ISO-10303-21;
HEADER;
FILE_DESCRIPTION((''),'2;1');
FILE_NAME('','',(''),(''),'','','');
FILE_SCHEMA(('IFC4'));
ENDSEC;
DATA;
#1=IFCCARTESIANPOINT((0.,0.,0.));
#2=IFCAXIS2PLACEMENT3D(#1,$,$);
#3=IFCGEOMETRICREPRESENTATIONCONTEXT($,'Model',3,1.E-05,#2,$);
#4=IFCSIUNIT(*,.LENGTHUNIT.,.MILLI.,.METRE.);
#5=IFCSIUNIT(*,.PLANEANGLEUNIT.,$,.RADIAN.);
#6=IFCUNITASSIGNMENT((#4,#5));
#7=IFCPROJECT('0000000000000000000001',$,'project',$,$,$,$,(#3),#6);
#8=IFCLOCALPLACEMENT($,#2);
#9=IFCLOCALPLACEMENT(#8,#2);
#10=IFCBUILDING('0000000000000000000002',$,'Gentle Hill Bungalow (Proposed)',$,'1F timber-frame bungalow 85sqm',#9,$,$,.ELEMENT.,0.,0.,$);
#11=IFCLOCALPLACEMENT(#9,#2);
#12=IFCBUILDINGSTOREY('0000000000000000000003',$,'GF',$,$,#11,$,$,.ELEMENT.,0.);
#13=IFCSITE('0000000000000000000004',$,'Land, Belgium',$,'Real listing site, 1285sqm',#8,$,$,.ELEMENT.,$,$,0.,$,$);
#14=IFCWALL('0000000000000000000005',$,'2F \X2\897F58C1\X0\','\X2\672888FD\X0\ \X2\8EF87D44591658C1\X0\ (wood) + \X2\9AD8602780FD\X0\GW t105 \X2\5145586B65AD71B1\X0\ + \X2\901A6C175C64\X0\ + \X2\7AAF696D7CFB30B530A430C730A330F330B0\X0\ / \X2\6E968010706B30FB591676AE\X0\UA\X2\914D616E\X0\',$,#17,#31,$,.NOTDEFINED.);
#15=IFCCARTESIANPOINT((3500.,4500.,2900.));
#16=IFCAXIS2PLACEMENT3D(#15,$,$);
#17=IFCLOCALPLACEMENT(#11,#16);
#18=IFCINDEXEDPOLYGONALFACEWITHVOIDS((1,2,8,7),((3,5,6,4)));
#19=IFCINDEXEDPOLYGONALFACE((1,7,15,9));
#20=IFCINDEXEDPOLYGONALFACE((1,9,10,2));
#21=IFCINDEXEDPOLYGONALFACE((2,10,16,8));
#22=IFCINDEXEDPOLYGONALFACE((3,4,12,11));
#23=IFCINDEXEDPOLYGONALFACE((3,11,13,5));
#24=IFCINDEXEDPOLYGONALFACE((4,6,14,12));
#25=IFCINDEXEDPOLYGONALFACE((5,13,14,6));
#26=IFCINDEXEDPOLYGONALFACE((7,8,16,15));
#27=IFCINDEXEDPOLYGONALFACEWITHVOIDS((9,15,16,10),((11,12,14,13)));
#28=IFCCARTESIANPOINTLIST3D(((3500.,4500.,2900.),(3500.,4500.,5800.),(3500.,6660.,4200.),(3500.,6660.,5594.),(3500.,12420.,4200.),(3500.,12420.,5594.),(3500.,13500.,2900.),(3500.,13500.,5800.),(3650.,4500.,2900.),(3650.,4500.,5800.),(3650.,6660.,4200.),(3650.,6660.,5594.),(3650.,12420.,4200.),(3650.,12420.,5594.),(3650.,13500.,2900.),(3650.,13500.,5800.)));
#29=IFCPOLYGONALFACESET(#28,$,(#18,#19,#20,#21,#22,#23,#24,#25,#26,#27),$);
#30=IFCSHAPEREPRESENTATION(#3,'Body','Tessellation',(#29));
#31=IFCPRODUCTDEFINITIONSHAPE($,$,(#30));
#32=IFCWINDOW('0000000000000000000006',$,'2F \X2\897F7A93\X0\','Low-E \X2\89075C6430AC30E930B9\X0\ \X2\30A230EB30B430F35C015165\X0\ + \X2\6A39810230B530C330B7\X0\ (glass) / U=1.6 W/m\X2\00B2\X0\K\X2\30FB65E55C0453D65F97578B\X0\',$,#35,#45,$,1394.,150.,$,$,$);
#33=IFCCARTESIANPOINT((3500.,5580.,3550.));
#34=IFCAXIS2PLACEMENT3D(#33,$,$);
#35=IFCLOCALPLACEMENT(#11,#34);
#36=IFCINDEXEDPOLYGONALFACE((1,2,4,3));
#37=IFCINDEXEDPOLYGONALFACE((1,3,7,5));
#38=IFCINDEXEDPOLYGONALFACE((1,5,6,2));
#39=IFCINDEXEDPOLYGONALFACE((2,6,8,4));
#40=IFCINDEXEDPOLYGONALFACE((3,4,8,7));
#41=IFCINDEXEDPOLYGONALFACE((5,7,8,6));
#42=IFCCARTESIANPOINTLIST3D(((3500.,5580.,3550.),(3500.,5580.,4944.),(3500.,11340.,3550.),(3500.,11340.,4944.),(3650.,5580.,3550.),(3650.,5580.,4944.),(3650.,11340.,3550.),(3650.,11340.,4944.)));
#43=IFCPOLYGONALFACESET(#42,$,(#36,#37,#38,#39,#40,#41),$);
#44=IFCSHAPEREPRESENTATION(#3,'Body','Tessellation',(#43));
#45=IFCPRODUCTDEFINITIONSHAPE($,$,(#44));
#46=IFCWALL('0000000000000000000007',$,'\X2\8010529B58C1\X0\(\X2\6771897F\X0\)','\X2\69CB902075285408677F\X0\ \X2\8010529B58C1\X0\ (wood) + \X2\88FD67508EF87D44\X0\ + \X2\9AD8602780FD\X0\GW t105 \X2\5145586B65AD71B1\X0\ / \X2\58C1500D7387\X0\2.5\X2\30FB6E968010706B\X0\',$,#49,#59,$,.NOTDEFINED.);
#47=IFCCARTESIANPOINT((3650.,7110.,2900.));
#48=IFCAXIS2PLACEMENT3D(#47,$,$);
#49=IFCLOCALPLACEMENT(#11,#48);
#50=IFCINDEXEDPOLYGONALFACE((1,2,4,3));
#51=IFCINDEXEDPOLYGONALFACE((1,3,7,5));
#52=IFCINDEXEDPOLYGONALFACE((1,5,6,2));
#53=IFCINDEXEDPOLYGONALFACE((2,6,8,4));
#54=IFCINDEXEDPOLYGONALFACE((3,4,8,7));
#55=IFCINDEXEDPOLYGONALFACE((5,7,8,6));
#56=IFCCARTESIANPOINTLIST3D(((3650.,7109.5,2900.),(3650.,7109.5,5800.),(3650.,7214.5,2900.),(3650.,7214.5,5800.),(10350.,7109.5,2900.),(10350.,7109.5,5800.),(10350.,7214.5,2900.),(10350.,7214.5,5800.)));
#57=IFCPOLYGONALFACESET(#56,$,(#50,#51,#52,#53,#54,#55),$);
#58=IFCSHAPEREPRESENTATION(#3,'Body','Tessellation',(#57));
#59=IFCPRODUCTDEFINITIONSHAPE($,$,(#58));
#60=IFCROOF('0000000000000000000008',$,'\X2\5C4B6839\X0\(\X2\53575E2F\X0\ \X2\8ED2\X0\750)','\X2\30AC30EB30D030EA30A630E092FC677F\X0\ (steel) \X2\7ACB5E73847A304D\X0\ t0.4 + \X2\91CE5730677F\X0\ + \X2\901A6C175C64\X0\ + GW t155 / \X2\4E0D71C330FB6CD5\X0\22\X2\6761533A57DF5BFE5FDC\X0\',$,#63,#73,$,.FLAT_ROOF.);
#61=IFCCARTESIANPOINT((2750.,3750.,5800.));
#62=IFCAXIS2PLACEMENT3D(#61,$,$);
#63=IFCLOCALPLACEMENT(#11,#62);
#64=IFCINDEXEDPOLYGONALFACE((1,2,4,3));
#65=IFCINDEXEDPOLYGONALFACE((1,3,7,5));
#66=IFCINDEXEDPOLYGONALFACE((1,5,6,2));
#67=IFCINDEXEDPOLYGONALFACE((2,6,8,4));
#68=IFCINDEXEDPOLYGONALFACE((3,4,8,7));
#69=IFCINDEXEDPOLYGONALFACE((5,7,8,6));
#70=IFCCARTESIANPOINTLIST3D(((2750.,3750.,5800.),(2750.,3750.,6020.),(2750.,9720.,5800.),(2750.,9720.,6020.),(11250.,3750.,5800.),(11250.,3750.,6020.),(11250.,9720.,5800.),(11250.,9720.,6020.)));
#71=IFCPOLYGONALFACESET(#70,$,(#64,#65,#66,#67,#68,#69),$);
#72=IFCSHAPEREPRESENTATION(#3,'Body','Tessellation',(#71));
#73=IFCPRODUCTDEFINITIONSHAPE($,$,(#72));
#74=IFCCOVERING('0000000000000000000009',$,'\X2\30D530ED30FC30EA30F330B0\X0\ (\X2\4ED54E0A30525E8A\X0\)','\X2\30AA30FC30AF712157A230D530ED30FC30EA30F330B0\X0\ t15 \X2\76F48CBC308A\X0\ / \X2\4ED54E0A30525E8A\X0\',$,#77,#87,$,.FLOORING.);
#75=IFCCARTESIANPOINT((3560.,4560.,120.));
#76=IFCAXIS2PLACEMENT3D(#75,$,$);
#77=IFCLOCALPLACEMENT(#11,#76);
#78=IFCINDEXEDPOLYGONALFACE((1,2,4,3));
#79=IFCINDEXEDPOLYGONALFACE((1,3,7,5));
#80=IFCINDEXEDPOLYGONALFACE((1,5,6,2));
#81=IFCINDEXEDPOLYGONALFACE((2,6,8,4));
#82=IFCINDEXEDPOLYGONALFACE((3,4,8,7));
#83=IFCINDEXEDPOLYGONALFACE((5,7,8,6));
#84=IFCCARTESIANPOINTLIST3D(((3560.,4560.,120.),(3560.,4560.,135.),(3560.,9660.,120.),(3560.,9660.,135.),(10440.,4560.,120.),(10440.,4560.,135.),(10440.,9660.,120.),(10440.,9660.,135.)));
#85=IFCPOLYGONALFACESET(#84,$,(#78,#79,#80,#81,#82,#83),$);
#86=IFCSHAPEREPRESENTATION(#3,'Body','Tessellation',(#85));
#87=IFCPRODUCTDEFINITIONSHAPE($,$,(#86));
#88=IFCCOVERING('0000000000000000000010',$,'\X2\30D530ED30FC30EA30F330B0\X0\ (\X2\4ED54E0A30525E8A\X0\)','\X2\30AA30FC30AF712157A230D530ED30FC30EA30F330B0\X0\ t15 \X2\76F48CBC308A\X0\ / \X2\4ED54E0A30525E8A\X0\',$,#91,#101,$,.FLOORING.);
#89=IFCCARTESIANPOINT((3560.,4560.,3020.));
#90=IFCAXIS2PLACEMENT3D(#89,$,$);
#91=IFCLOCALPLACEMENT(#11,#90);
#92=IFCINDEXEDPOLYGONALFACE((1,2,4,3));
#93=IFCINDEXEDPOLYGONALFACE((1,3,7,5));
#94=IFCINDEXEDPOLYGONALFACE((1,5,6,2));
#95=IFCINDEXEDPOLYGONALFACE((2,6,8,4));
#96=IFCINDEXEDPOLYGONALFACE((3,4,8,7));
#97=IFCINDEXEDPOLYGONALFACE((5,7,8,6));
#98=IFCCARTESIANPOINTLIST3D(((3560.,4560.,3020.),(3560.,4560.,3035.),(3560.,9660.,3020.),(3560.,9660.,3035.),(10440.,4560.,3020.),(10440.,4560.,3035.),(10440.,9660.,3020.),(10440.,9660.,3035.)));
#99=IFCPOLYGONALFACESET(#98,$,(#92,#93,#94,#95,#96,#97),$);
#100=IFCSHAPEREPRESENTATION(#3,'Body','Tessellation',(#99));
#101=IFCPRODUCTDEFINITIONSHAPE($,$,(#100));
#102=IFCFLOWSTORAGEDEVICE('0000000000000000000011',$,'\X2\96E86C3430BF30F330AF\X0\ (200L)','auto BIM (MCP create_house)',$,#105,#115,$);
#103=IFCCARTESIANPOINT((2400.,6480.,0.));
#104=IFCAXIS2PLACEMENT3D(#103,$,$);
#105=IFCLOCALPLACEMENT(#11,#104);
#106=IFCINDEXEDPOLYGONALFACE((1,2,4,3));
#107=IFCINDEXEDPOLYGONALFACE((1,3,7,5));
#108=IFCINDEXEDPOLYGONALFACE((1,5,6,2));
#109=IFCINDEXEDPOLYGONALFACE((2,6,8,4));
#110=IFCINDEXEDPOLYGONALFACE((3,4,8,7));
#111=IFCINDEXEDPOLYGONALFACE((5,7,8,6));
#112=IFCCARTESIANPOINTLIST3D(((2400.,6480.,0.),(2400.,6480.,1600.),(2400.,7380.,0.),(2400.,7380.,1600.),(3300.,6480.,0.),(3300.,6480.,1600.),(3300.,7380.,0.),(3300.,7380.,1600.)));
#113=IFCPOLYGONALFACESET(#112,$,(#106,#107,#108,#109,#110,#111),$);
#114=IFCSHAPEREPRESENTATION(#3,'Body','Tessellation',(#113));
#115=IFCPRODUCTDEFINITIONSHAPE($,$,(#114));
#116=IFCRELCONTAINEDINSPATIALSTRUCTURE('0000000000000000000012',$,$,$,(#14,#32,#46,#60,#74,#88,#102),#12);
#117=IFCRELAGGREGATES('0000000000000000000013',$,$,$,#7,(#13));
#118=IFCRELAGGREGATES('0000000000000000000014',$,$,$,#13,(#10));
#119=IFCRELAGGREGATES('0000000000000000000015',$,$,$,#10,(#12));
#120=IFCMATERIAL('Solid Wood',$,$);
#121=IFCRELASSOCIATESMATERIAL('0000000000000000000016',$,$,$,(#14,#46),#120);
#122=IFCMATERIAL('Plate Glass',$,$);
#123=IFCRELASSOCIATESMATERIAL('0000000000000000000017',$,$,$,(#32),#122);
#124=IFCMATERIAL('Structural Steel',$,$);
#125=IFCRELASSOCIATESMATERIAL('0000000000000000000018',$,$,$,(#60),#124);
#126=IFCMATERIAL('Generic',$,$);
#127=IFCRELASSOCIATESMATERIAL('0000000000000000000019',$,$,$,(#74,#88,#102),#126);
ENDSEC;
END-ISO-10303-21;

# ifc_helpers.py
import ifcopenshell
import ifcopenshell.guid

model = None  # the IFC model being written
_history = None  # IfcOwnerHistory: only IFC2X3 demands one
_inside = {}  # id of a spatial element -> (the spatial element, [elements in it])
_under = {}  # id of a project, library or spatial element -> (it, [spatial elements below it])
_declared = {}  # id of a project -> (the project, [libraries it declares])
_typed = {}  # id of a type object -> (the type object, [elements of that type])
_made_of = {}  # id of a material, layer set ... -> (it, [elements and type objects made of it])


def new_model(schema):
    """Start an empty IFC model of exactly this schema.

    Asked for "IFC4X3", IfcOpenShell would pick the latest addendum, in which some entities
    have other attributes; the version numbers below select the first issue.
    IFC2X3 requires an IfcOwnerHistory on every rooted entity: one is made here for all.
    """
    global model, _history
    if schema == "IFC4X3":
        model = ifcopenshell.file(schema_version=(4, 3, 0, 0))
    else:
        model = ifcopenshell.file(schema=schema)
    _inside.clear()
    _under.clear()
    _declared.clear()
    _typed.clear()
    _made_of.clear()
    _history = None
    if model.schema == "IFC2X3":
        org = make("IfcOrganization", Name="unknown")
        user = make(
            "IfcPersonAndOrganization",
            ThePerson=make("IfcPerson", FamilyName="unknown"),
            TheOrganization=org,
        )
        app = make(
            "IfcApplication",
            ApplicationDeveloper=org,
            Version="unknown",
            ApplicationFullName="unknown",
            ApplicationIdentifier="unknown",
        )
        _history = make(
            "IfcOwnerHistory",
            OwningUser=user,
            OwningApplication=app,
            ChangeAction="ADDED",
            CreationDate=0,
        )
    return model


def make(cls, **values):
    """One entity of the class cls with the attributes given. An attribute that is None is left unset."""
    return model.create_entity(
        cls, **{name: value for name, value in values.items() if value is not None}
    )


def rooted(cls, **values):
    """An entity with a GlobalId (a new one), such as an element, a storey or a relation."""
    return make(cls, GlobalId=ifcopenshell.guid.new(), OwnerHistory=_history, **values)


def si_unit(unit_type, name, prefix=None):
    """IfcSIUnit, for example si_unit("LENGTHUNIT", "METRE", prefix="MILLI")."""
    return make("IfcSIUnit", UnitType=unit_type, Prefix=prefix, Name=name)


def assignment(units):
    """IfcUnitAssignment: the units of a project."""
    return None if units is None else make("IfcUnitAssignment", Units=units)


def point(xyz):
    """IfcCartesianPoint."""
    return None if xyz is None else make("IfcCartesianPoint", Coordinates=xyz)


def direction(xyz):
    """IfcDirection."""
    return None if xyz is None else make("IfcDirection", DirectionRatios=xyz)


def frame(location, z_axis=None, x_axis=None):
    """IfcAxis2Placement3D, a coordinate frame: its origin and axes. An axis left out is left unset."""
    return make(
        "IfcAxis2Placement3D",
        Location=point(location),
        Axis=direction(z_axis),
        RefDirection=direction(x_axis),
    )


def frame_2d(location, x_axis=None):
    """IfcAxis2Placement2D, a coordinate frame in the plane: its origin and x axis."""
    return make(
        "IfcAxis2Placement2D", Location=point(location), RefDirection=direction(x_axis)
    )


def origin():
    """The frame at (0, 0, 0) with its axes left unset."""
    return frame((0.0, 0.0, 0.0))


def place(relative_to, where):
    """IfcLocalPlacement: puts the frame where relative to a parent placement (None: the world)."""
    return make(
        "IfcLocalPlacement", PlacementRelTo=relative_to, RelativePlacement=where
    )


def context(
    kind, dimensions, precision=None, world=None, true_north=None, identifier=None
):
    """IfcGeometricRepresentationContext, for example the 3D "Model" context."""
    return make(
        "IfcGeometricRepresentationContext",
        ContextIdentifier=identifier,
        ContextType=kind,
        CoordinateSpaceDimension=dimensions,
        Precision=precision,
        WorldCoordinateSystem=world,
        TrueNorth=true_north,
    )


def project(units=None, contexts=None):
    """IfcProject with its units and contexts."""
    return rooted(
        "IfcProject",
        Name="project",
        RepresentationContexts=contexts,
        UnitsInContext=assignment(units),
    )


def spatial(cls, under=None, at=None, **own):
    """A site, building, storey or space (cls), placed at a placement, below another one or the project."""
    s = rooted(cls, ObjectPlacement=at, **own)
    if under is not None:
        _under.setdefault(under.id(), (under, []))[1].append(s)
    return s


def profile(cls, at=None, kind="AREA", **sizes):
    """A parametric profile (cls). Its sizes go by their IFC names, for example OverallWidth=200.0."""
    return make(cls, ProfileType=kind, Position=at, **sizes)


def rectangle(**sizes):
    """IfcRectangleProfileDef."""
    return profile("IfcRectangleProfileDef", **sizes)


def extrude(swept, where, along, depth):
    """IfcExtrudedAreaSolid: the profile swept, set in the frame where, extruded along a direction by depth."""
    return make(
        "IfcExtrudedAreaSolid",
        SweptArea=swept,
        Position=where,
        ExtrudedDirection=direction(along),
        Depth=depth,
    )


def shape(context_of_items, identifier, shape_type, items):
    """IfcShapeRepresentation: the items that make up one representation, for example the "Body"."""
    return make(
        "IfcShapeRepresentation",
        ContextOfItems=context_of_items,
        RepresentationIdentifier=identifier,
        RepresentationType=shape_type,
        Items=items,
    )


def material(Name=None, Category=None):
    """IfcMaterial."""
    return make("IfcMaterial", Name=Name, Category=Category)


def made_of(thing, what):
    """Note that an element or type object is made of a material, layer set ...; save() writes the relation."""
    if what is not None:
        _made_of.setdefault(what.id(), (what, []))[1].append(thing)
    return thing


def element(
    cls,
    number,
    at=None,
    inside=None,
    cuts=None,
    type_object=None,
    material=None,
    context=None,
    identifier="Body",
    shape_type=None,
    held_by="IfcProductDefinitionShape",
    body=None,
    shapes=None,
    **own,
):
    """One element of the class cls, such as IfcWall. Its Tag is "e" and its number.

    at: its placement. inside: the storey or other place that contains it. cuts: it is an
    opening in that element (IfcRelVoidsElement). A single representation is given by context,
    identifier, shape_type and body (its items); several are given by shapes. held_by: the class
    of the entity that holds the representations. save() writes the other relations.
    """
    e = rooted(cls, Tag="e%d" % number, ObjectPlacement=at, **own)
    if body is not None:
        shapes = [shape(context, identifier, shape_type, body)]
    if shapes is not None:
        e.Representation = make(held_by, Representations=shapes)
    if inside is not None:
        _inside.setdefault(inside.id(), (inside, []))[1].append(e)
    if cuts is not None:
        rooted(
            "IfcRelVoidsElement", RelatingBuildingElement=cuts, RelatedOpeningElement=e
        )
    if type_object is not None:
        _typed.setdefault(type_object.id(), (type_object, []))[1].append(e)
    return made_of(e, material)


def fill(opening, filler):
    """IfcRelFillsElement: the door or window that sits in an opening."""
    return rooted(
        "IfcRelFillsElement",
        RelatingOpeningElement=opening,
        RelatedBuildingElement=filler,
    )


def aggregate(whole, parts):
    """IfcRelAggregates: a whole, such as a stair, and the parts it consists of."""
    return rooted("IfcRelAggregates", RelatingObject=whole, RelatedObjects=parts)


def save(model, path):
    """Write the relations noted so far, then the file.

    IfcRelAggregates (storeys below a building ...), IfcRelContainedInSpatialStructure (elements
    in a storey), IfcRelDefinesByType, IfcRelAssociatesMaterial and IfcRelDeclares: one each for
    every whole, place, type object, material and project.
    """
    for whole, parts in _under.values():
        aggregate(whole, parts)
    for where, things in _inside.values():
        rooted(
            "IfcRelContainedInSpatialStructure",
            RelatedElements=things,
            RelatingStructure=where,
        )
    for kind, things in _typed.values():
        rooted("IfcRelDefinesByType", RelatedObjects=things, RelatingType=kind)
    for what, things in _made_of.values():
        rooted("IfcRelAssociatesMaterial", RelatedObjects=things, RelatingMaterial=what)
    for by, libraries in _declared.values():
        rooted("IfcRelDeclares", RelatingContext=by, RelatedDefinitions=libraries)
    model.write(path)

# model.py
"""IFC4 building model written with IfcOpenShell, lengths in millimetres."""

from ifc_helpers import new_model, si_unit, frame, frame_2d, origin, place, context, project, spatial, rectangle, extrude, material, element, fill, save


model = new_model("IFC4")

# Units and contexts
model_context = context("Model", 3, precision=1e-05, world=origin())
ifc_project = project(units=[si_unit("LENGTHUNIT", "METRE", prefix="MILLI"), si_unit("PLANEANGLEUNIT", "RADIAN")], contexts=[model_context])

# Site, building, storey
site_placement = place(None, origin())
site = spatial("IfcSite", under=ifc_project, at=site_placement, Name="Land, Belgium", ObjectType="Real listing site, 1285sqm", CompositionType="ELEMENT", RefElevation=0.0)
building_placement = place(site_placement, origin())
building = spatial("IfcBuilding", under=site, at=building_placement, Name="Gentle Hill Bungalow (Proposed)", ObjectType="1F timber-frame bungalow 85sqm", CompositionType="ELEMENT", ElevationOfRefHeight=0.0, ElevationOfTerrain=0.0)
storey_placement = place(building_placement, origin())
storey = spatial("IfcBuildingStorey", under=building, at=storey_placement, Name="GF", CompositionType="ELEMENT", Elevation=0.0)

# Shared definitions
ifc_material_1 = material(Name="Solid Wood")
ifc_material_2 = material(Name="Generic")

# Shared definitions
ifc_material_3 = material(Name="Plate Glass")

# Wall, opening, window
wall_1_placement = place(storey_placement, frame((3500.0, 4500.0, 2900.0)))
wall_1 = element("IfcWall", 1, at=wall_1_placement, inside=storey, material=ifc_material_1, Name="2F 西壁", Description="木製 軸組外壁 (wood) + 高性能GW t105 充填断熱 + 通気層 + 窯業系サイディング / 準耐火・外皮UA配慮", PredefinedType="NOTDEFINED", context=model_context, shape_type="SweptSolid", body=[
    extrude(rectangle(XDim=150.0, YDim=9000.0, at=frame_2d((75.0, 4500.0))), frame((3500.0, 4500.0, 2900.0)), (0.0, 0.0, 1.0), 2900.0),
])
opening_1_placement = place(storey_placement, frame((3500.0, 5580.0, 3550.0)))
opening_1 = element("IfcOpeningElement", 2, at=opening_1_placement, cuts=wall_1, PredefinedType="NOTDEFINED", context=model_context, shape_type="SweptSolid", body=[
    extrude(rectangle(XDim=150.0, YDim=5760.0, at=frame_2d((75.0, 2880.0))), frame((3500.0, 5580.0, 3550.0)), (0.0, 0.0, 1.0), 1394.0),
])
window_1_placement = place(storey_placement, frame((3500.0, 5580.0, 3550.0)))
window_1 = element("IfcWindow", 3, at=window_1_placement, inside=storey, material=ifc_material_3, Name="2F 西窓", Description="Low-E 複層ガラス アルゴン封入 + 樹脂サッシ (glass) / U=1.6 W/m²K・日射取得型", OverallHeight=1394.0, OverallWidth=150.0, context=model_context, shape_type="SweptSolid", body=[
    extrude(rectangle(XDim=150.0, YDim=5760.0, at=frame_2d((75.0, 2880.0))), frame((3500.0, 5580.0, 3550.0)), (0.0, 0.0, 1.0), 1394.0),
])
fill(opening_1, window_1)

# Wall
wall_2_placement = place(storey_placement, frame((3650.0, 7110.0, 2900.0)))
element("IfcWall", 4, at=wall_2_placement, inside=storey, material=ifc_material_1, Name="耐力壁(東西)", Description="構造用合板 耐力壁 (wood) + 製材軸組 + 高性能GW t105 充填断熱 / 壁倍率2.5・準耐火", PredefinedType="NOTDEFINED", context=model_context, shape_type="SweptSolid", body=[
    extrude(rectangle(XDim=6700.0, YDim=105.0, at=frame_2d((3350.0, 52.0))), frame((3650.0, 7110.0, 2900.0)), (0.0, 0.0, 1.0), 2900.0),
])

# Roof
ifc_material_4 = material(Name="Structural Steel")
for number, where, name in (
    (5, (2750.0, 3750.0, 5800.0), "屋根(南帯 軒750)"),
):
    element("IfcRoof", number, at=place(storey_placement, frame(where)), inside=storey, material=ifc_material_4, Name=name, Description="ガルバリウム鋼板 (steel) 立平葺き t0.4 + 野地板 + 通気層 + GW t155 / 不燃・法22条区域対応", PredefinedType="FLAT_ROOF", context=model_context, shape_type="SweptSolid", body=[
        extrude(rectangle(XDim=8500.0, YDim=5970.0, at=frame_2d((4250.0, 2985.0))), frame((2750.0, 3750.0, 5800.0)), (0.0, 0.0, 1.0), 220.0),
    ])

# Coverings
covering_1_placement = place(storey_placement, frame((3560.0, 4560.0, 120.0)))
element("IfcCovering", 6, at=covering_1_placement, inside=storey, material=ifc_material_2, Name="フローリング (仕上げ床)", Description="オーク無垢フローリング t15 直貼り / 仕上げ床", PredefinedType="FLOORING", context=model_context, shape_type="SweptSolid", body=[
    extrude(rectangle(XDim=6880.0, YDim=5100.0, at=frame_2d((3440.0, 2550.0))), frame((3560.0, 4560.0, 120.0)), (0.0, 0.0, 1.0), 15.0),
])
covering_2_placement = place(storey_placement, frame((3560.0, 4560.0, 3020.0)))
element("IfcCovering", 7, at=covering_2_placement, inside=storey, material=ifc_material_2, Name="フローリング (仕上げ床)", Description="オーク無垢フローリング t15 直貼り / 仕上げ床", PredefinedType="FLOORING", context=model_context, shape_type="SweptSolid", body=[
    extrude(rectangle(XDim=6880.0, YDim=5100.0, at=frame_2d((3440.0, 2550.0))), frame((3560.0, 4560.0, 3020.0)), (0.0, 0.0, 1.0), 15.0),
])

# Flow storage device
flow_storage_device_placement = place(storey_placement, frame((2400.0, 6480.0, 0.0)))
element("IfcFlowStorageDevice", 8, at=flow_storage_device_placement, inside=storey, material=ifc_material_2, Name="雨水タンク (200L)", Description="auto BIM (MCP create_house)", context=model_context, shape_type="SweptSolid", body=[
    extrude(rectangle(XDim=900.0, YDim=900.0, at=frame_2d((450.0, 450.0))), frame((2400.0, 6480.0, 0.0)), (0.0, 0.0, 1.0), 1600.0),
])

save(model, "model.ifc")
